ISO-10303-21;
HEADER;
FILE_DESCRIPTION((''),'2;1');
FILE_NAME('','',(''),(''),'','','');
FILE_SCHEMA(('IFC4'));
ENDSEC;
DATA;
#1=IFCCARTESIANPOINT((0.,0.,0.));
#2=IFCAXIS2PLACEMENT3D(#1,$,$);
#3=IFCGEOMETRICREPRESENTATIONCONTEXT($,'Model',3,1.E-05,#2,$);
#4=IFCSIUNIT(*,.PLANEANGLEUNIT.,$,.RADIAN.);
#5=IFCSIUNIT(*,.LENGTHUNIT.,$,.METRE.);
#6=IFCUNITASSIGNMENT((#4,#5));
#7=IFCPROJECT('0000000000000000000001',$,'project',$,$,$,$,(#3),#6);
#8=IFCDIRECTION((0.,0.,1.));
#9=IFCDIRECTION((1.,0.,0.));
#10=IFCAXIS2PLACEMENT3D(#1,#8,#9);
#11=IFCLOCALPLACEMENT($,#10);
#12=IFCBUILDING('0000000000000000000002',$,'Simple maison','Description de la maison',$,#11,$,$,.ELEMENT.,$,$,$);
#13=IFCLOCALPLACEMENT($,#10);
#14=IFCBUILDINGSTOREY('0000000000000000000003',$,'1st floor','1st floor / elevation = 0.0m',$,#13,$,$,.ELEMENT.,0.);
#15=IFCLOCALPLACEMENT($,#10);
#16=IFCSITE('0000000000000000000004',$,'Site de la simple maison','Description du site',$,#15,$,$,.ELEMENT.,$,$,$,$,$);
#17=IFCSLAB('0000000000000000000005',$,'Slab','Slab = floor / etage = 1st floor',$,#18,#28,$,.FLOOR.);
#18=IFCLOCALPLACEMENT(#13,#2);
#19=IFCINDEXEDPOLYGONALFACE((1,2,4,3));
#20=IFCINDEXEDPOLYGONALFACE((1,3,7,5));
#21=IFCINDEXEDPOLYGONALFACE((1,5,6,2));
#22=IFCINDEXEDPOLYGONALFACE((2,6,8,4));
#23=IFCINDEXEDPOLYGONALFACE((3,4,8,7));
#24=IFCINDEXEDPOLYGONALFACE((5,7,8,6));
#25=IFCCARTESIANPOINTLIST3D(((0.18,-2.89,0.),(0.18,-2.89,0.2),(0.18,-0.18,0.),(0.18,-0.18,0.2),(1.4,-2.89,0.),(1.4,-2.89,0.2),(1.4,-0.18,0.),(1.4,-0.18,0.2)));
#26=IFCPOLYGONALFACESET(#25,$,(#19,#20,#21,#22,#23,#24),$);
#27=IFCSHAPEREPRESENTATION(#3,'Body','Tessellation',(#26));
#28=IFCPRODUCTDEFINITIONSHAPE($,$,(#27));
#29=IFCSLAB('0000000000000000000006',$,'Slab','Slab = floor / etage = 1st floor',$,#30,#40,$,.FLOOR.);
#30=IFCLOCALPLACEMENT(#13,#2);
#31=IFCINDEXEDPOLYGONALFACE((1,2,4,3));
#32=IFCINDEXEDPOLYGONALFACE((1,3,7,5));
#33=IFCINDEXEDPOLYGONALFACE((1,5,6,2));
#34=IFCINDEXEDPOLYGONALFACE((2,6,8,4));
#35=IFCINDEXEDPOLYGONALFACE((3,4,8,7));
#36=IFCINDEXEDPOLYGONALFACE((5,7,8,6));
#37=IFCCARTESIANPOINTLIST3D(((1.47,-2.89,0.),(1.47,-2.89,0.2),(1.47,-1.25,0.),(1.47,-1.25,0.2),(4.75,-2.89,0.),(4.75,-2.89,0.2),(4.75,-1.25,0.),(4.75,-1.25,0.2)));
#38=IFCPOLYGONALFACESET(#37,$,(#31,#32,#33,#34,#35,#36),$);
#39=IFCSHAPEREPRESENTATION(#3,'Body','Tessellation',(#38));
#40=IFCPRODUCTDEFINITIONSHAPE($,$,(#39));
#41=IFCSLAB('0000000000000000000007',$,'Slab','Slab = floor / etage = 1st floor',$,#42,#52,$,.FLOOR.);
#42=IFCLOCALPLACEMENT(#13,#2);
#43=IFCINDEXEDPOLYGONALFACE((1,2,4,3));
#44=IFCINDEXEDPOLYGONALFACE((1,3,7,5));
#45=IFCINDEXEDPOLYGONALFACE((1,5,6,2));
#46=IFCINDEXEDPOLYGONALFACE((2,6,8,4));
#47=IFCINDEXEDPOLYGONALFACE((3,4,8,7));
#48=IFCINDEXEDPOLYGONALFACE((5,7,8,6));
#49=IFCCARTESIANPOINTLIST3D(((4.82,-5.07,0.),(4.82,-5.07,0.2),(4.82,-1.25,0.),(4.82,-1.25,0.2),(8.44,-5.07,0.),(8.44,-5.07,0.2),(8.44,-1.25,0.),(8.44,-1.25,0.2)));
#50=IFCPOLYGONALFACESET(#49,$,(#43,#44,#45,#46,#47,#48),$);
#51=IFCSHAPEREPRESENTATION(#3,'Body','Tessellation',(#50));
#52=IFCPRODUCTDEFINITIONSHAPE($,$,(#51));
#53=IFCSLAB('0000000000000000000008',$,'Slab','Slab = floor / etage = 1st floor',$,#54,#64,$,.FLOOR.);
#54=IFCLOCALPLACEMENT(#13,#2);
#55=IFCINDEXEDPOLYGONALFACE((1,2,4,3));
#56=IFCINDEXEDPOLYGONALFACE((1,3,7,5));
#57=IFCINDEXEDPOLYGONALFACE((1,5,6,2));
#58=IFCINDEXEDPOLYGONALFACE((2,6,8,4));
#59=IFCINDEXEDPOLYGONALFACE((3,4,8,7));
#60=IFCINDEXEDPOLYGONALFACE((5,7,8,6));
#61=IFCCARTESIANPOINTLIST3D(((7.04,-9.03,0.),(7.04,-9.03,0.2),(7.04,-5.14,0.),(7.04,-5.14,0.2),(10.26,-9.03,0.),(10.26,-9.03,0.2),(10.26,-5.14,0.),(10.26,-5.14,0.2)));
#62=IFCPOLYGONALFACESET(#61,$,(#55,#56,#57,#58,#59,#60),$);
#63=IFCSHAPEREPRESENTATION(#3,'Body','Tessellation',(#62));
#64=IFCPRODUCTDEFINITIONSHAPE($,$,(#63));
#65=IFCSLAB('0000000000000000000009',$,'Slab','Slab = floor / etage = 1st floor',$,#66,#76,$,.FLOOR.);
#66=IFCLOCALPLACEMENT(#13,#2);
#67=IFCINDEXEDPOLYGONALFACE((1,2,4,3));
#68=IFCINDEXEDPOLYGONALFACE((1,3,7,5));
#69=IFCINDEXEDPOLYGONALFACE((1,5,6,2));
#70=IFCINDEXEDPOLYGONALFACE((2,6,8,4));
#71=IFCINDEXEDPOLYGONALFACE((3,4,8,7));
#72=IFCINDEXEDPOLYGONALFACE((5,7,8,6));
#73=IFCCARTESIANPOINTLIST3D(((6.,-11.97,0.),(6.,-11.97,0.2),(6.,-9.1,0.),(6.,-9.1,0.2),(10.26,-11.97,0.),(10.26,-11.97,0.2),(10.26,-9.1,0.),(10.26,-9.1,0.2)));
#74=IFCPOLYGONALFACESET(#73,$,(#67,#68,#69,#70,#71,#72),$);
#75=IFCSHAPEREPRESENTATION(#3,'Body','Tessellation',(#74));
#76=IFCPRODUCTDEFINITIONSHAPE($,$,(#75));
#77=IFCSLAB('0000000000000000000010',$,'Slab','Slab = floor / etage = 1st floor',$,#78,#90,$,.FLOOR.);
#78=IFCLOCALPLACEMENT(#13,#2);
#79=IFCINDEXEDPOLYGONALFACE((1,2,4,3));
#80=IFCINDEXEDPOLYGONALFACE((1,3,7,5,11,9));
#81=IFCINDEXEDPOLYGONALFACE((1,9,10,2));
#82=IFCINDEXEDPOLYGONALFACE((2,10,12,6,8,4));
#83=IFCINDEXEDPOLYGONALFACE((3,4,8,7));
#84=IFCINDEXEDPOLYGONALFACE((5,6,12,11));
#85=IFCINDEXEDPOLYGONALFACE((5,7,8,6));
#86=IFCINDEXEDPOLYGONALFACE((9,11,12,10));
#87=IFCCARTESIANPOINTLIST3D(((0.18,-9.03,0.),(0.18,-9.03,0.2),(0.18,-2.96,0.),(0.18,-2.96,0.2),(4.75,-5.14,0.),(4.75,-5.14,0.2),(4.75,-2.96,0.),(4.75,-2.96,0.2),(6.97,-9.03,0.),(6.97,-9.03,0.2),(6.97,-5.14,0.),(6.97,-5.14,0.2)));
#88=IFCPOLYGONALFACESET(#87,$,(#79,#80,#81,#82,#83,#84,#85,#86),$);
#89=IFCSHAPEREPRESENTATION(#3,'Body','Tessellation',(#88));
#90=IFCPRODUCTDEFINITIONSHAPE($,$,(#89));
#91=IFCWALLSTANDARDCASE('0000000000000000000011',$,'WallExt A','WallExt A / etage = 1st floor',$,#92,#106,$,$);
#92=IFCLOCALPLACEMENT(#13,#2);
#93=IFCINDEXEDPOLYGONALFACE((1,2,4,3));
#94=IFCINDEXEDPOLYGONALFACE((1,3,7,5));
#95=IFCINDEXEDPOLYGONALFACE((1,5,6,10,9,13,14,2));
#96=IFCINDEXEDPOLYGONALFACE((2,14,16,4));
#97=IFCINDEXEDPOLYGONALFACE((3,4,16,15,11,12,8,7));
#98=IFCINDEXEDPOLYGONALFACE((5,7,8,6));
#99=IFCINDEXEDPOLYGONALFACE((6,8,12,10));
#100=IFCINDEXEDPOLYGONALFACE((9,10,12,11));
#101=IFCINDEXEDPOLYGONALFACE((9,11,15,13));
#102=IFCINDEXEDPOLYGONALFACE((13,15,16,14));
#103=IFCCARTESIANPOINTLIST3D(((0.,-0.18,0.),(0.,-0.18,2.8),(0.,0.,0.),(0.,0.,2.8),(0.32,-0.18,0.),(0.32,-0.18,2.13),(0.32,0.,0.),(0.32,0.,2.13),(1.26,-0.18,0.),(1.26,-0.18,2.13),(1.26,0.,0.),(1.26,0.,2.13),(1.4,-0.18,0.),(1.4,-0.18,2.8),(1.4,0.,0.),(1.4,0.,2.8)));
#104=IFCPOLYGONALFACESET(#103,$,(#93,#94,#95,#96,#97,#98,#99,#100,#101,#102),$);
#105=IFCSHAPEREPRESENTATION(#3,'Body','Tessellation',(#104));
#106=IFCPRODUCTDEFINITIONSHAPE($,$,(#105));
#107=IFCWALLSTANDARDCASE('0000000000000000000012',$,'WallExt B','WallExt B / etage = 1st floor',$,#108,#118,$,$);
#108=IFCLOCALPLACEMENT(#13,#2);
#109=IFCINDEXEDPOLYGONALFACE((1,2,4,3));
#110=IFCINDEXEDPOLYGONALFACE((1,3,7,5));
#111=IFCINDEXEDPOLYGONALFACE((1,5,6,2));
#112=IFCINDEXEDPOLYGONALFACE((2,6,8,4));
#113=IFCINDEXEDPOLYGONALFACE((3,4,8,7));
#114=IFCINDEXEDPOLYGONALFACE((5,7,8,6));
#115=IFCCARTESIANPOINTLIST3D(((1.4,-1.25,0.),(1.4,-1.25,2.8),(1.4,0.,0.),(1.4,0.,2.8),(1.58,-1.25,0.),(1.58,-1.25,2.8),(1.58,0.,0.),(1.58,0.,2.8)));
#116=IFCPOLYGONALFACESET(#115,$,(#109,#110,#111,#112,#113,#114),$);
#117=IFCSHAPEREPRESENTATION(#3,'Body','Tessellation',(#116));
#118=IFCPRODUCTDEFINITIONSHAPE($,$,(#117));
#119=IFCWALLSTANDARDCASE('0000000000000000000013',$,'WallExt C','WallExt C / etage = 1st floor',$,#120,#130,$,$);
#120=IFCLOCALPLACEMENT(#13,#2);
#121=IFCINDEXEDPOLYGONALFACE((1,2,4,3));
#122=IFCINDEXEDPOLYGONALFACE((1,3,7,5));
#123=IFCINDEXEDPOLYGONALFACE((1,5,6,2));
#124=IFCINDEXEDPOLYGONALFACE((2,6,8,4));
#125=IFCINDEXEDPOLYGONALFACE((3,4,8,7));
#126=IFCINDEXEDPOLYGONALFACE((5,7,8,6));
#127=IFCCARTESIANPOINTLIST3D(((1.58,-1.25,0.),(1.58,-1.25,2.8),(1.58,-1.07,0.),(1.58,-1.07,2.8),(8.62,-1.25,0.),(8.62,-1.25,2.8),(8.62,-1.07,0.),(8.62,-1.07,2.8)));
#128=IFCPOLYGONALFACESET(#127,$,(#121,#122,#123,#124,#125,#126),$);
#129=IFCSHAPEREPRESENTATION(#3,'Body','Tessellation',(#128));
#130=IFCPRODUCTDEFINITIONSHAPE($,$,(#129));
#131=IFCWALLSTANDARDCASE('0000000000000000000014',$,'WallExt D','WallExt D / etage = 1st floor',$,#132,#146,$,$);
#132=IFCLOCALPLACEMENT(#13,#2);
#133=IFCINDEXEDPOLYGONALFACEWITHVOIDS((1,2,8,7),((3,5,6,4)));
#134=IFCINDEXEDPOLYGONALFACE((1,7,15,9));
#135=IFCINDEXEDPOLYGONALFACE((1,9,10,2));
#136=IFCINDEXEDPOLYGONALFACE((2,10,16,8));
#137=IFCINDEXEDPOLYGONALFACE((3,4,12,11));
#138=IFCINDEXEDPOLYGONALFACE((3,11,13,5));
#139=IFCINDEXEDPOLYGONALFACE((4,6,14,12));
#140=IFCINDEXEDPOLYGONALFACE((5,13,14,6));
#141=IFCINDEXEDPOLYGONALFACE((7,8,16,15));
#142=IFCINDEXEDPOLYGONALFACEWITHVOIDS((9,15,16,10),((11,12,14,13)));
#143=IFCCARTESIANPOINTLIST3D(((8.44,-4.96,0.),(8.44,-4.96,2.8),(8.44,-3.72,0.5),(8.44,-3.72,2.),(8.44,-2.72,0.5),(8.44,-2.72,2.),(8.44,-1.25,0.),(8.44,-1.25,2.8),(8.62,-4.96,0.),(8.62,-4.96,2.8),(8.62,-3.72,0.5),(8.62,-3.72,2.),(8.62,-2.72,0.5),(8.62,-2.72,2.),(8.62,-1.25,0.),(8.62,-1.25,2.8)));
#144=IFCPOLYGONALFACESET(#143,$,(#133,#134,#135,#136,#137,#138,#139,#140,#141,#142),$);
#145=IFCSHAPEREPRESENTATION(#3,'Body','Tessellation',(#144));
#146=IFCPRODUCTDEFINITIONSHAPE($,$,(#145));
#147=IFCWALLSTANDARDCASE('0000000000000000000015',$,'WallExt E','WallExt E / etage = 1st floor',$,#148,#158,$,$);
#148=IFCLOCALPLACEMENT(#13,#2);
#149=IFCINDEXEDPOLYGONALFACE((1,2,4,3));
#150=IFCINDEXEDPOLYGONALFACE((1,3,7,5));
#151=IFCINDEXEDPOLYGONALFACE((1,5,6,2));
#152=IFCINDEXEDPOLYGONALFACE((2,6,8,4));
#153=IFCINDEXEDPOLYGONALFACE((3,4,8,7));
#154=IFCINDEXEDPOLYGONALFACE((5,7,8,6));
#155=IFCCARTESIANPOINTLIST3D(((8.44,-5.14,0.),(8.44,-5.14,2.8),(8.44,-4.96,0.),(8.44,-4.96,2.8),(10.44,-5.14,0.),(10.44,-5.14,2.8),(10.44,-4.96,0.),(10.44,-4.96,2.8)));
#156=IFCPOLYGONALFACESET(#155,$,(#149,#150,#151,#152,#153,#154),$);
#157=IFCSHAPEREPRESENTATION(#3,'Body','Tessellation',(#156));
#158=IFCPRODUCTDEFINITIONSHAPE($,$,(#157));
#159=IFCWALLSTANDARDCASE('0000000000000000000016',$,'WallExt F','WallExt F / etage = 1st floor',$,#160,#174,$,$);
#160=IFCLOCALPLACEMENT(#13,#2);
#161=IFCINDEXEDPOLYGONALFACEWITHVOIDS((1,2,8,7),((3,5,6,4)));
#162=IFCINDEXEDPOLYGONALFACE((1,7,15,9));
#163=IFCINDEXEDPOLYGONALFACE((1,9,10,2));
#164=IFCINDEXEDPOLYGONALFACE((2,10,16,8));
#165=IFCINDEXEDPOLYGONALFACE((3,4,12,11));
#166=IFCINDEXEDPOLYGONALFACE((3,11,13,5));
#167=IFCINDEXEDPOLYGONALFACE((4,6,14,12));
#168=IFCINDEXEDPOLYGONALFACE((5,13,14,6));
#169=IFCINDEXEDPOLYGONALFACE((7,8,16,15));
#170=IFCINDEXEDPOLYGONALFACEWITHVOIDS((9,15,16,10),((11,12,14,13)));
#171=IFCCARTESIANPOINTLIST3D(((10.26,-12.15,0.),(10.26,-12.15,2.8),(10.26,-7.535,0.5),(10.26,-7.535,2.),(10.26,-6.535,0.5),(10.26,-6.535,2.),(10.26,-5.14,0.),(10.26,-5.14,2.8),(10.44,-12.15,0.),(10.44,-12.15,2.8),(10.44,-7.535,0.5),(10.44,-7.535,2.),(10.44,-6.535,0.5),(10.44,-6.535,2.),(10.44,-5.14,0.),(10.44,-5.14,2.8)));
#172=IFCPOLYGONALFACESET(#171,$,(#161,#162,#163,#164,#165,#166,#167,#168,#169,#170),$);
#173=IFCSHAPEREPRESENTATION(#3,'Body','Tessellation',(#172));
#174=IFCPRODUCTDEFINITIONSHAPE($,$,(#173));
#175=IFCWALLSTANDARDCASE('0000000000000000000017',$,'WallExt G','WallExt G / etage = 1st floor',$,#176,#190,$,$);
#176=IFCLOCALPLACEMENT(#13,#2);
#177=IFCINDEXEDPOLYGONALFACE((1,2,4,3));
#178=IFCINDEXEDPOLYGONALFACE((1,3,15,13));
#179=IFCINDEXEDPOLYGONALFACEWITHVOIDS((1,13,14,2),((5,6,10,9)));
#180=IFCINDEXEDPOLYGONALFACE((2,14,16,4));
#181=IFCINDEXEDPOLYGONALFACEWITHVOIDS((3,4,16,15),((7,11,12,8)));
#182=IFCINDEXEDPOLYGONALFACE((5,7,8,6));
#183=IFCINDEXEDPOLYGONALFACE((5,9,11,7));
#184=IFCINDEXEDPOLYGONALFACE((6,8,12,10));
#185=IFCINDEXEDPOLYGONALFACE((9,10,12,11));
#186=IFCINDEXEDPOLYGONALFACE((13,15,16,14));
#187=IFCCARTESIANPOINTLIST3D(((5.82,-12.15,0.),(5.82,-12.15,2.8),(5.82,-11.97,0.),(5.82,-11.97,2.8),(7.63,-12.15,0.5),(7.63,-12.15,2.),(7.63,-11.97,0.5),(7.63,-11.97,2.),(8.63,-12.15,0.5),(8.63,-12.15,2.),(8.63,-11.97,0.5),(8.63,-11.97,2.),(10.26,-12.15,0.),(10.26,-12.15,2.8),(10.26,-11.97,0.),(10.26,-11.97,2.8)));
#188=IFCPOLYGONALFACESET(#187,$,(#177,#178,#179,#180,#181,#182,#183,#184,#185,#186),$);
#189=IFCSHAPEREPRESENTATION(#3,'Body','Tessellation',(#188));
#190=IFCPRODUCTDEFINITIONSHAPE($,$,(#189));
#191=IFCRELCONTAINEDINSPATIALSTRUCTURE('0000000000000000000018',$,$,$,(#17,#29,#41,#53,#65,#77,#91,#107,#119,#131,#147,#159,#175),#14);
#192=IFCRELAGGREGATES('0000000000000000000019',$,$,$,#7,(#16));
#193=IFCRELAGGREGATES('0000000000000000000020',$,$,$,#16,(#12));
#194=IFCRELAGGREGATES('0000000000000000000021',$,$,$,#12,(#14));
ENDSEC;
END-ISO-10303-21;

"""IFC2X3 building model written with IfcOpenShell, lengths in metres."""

from ifc_helpers import new_model, si_unit, frame, origin, origin_with_axes, origin_2d_with_axis, place, context, project, spatial, polyline, rectangle, outline, extrude, element, save


model = new_model("IFC2X3")

# Units and contexts
model_context = context("Model", 3, precision=1e-05, world=origin())
ifc_project = project(units=[si_unit("PLANEANGLEUNIT", "RADIAN"), si_unit("LENGTHUNIT", "METRE")], contexts=[model_context])

# Site, building, storey
site_placement = place(None, origin_with_axes())
site = spatial("IfcSite", under=ifc_project, at=site_placement, Name="Site de la simple maison", Description="Description du site", CompositionType="ELEMENT")
building_placement = place(None, origin_with_axes())
building = spatial("IfcBuilding", under=site, at=building_placement, Name="Simple maison", Description="Description de la maison", CompositionType="ELEMENT")
storey_placement = place(None, origin_with_axes())
storey = spatial("IfcBuildingStorey", under=building, at=storey_placement, Name="1st floor", Description="1st floor / elevation = 0.0m", CompositionType="ELEMENT", Elevation=0.0)

# Slabs
slab_1_placement = place(storey_placement, origin_with_axes())
element("IfcSlab", 1, at=slab_1_placement, inside=storey, Name="Slab", Description="Slab = floor / etage = 1st floor", PredefinedType="FLOOR", context=model_context, shape_type="SweptSolid", body=[
    extrude(outline(polyline([(0.18, -0.18), (1.4, -0.18), (1.4, -2.89), (0.18, -2.89)])), origin(), (0.0, 0.0, 1.0), 0.2),
])
slab_2_placement = place(storey_placement, origin_with_axes())
element("IfcSlab", 2, at=slab_2_placement, inside=storey, Name="Slab", Description="Slab = floor / etage = 1st floor", PredefinedType="FLOOR", context=model_context, shape_type="SweptSolid", body=[
    extrude(outline(polyline([(1.47, -1.25), (4.75, -1.25), (4.75, -2.89), (1.47, -2.89)])), origin(), (0.0, 0.0, 1.0), 0.2),
])
slab_3_placement = place(storey_placement, origin_with_axes())
element("IfcSlab", 3, at=slab_3_placement, inside=storey, Name="Slab", Description="Slab = floor / etage = 1st floor", PredefinedType="FLOOR", context=model_context, shape_type="SweptSolid", body=[
    extrude(outline(polyline([(4.82, -1.25), (8.44, -1.25), (8.44, -5.07), (4.82, -5.07)])), origin(), (0.0, 0.0, 1.0), 0.2),
])
slab_4_placement = place(storey_placement, origin_with_axes())
element("IfcSlab", 4, at=slab_4_placement, inside=storey, Name="Slab", Description="Slab = floor / etage = 1st floor", PredefinedType="FLOOR", context=model_context, shape_type="SweptSolid", body=[
    extrude(outline(polyline([(7.04, -5.14), (10.26, -5.14), (10.26, -9.03), (7.04, -9.03)])), origin(), (0.0, 0.0, 1.0), 0.2),
])
slab_5_placement = place(storey_placement, origin_with_axes())
element("IfcSlab", 5, at=slab_5_placement, inside=storey, Name="Slab", Description="Slab = floor / etage = 1st floor", PredefinedType="FLOOR", context=model_context, shape_type="SweptSolid", body=[
    extrude(outline(polyline([(6.0, -9.1), (10.26, -9.1), (10.26, -11.97), (6.0, -11.97)])), origin(), (0.0, 0.0, 1.0), 0.2),
])
slab_6_placement = place(storey_placement, origin_with_axes())
element("IfcSlab", 6, at=slab_6_placement, inside=storey, Name="Slab", Description="Slab = floor / etage = 1st floor", PredefinedType="FLOOR", context=model_context, shape_type="SweptSolid", body=[
    extrude(outline(polyline([(0.18, -2.96), (4.75, -2.96), (4.75, -5.14), (6.97, -5.14), (6.97, -9.03), (0.18, -9.03)])), origin(), (0.0, 0.0, 1.0), 0.2),
])

# Wall, opening
wall_1_placement = place(storey_placement, frame((0.0, -0.09, 0.0), z_axis=(0.0, 0.0, 1.0), x_axis=(1.0, 0.0, 0.0)))
wall_1 = element("IfcWallStandardCase", 7, at=wall_1_placement, inside=storey, Name="WallExt A", Description="WallExt A / etage = 1st floor", context=model_context, shape_type="SweptSolid", body=[
    extrude(outline(polyline([(0.0, 0.09), (1.4, 0.09), (1.4, -0.09), (0.0, -0.09)])), origin(), (0.0, 0.0, 1.0), 2.8),
])
opening_1_placement = place(wall_1_placement, frame((0.32, -0.09, 0.0), z_axis=(0.0, 0.0, 1.0), x_axis=(1.0, 0.0, 0.0)))
element("IfcOpeningElement", 8, at=opening_1_placement, cuts=wall_1, context=model_context, shape_type="SweptSolid", body=[
    extrude(rectangle(XDim=2.13, YDim=0.94, at=origin_2d_with_axis()), frame((0.47, 0.0, 1.065), z_axis=(0.0, 1.0, 0.0), x_axis=(0.0, 0.0, 1.0)), (0.0, 0.0, 1.0), 0.18),
])

# Walls
wall_2_placement = place(storey_placement, frame((1.49, 0.0, 0.0), z_axis=(0.0, 0.0, 1.0), x_axis=(0.0, -1.0, 0.0)))
element("IfcWallStandardCase", 9, at=wall_2_placement, inside=storey, Name="WallExt B", Description="WallExt B / etage = 1st floor", context=model_context, shape_type="SweptSolid", body=[
    extrude(outline(polyline([(0.0, 0.09), (1.25, 0.09), (1.25, -0.09), (0.0, -0.09)])), origin(), (0.0, 0.0, 1.0), 2.8),
])
wall_3_placement = place(storey_placement, frame((1.58, -1.16, 0.0), z_axis=(0.0, 0.0, 1.0), x_axis=(1.0, 0.0, 0.0)))
element("IfcWallStandardCase", 10, at=wall_3_placement, inside=storey, Name="WallExt C", Description="WallExt C / etage = 1st floor", context=model_context, shape_type="SweptSolid", body=[
    extrude(outline(polyline([(0.0, 0.09), (7.04, 0.09), (7.04, -0.09), (0.0, -0.09)])), origin(), (0.0, 0.0, 1.0), 2.8),
])

# Wall, opening
wall_4_placement = place(storey_placement, frame((8.53, -1.25, 0.0), z_axis=(0.0, 0.0, 1.0), x_axis=(0.0, -1.0, 0.0)))
wall_4 = element("IfcWallStandardCase", 11, at=wall_4_placement, inside=storey, Name="WallExt D", Description="WallExt D / etage = 1st floor", context=model_context, shape_type="SweptSolid", body=[
    extrude(outline(polyline([(0.0, 0.09), (3.71, 0.09), (3.71, -0.09), (0.0, -0.09)])), origin(), (0.0, 0.0, 1.0), 2.8),
])
opening_2_placement = place(wall_4_placement, frame((1.47, -0.09, 0.5), z_axis=(0.0, 0.0, 1.0), x_axis=(1.0, 0.0, 0.0)))
element("IfcOpeningElement", 12, at=opening_2_placement, cuts=wall_4, context=model_context, shape_type="SweptSolid", body=[
    extrude(rectangle(XDim=1.5, YDim=1.0, at=origin_2d_with_axis()), frame((0.5, 0.0, 0.75), z_axis=(0.0, 1.0, 0.0), x_axis=(0.0, 0.0, 1.0)), (0.0, 0.0, 1.0), 0.18),
])

# Wall
wall_5_placement = place(storey_placement, frame((8.44, -5.05, 0.0), z_axis=(0.0, 0.0, 1.0), x_axis=(1.0, 0.0, 0.0)))
element("IfcWallStandardCase", 13, at=wall_5_placement, inside=storey, Name="WallExt E", Description="WallExt E / etage = 1st floor", context=model_context, shape_type="SweptSolid", body=[
    extrude(outline(polyline([(0.0, 0.09), (2.0, 0.09), (2.0, -0.09), (0.0, -0.09)])), origin(), (0.0, 0.0, 1.0), 2.8),
])

# Walls, openings
wall_6_placement = place(storey_placement, frame((10.35, -5.14, 0.0), z_axis=(0.0, 0.0, 1.0), x_axis=(0.0, -1.0, 0.0)))
wall_6 = element("IfcWallStandardCase", 14, at=wall_6_placement, inside=storey, Name="WallExt F", Description="WallExt F / etage = 1st floor", context=model_context, shape_type="SweptSolid", body=[
    extrude(outline(polyline([(0.0, 0.09), (7.01, 0.09), (7.01, -0.09), (0.0, -0.09)])), origin(), (0.0, 0.0, 1.0), 2.8),
])
opening_3_placement = place(wall_6_placement, frame((1.395, -0.09, 0.5), z_axis=(0.0, 0.0, 1.0), x_axis=(1.0, 0.0, 0.0)))
element("IfcOpeningElement", 15, at=opening_3_placement, cuts=wall_6, context=model_context, shape_type="SweptSolid", body=[
    extrude(rectangle(XDim=1.5, YDim=1.0, at=origin_2d_with_axis()), frame((0.5, 0.0, 0.75), z_axis=(0.0, 1.0, 0.0), x_axis=(0.0, 0.0, 1.0)), (0.0, 0.0, 1.0), 0.18),
])
wall_7_placement = place(storey_placement, frame((10.26, -12.06, 0.0), z_axis=(0.0, 0.0, 1.0), x_axis=(-1.0, 0.0, 0.0)))
wall_7 = element("IfcWallStandardCase", 16, at=wall_7_placement, inside=storey, Name="WallExt G", Description="WallExt G / etage = 1st floor", context=model_context, shape_type="SweptSolid", body=[
    extrude(outline(polyline([(0.0, 0.09), (4.44, 0.09), (4.44, -0.09), (0.0, -0.09)])), origin(), (0.0, 0.0, 1.0), 2.8),
])
opening_4_placement = place(wall_7_placement, frame((1.63, -0.09, 0.5), z_axis=(0.0, 0.0, 1.0), x_axis=(1.0, 0.0, 0.0)))
element("IfcOpeningElement", 17, at=opening_4_placement, cuts=wall_7, context=model_context, shape_type="SweptSolid", body=[
    extrude(rectangle(XDim=1.5, YDim=1.0, at=origin_2d_with_axis()), frame((0.5, 0.0, 0.75), z_axis=(0.0, 1.0, 0.0), x_axis=(0.0, 0.0, 1.0)), (0.0, 0.0, 1.0), 0.18),
])

save(model, "model.ifc")
